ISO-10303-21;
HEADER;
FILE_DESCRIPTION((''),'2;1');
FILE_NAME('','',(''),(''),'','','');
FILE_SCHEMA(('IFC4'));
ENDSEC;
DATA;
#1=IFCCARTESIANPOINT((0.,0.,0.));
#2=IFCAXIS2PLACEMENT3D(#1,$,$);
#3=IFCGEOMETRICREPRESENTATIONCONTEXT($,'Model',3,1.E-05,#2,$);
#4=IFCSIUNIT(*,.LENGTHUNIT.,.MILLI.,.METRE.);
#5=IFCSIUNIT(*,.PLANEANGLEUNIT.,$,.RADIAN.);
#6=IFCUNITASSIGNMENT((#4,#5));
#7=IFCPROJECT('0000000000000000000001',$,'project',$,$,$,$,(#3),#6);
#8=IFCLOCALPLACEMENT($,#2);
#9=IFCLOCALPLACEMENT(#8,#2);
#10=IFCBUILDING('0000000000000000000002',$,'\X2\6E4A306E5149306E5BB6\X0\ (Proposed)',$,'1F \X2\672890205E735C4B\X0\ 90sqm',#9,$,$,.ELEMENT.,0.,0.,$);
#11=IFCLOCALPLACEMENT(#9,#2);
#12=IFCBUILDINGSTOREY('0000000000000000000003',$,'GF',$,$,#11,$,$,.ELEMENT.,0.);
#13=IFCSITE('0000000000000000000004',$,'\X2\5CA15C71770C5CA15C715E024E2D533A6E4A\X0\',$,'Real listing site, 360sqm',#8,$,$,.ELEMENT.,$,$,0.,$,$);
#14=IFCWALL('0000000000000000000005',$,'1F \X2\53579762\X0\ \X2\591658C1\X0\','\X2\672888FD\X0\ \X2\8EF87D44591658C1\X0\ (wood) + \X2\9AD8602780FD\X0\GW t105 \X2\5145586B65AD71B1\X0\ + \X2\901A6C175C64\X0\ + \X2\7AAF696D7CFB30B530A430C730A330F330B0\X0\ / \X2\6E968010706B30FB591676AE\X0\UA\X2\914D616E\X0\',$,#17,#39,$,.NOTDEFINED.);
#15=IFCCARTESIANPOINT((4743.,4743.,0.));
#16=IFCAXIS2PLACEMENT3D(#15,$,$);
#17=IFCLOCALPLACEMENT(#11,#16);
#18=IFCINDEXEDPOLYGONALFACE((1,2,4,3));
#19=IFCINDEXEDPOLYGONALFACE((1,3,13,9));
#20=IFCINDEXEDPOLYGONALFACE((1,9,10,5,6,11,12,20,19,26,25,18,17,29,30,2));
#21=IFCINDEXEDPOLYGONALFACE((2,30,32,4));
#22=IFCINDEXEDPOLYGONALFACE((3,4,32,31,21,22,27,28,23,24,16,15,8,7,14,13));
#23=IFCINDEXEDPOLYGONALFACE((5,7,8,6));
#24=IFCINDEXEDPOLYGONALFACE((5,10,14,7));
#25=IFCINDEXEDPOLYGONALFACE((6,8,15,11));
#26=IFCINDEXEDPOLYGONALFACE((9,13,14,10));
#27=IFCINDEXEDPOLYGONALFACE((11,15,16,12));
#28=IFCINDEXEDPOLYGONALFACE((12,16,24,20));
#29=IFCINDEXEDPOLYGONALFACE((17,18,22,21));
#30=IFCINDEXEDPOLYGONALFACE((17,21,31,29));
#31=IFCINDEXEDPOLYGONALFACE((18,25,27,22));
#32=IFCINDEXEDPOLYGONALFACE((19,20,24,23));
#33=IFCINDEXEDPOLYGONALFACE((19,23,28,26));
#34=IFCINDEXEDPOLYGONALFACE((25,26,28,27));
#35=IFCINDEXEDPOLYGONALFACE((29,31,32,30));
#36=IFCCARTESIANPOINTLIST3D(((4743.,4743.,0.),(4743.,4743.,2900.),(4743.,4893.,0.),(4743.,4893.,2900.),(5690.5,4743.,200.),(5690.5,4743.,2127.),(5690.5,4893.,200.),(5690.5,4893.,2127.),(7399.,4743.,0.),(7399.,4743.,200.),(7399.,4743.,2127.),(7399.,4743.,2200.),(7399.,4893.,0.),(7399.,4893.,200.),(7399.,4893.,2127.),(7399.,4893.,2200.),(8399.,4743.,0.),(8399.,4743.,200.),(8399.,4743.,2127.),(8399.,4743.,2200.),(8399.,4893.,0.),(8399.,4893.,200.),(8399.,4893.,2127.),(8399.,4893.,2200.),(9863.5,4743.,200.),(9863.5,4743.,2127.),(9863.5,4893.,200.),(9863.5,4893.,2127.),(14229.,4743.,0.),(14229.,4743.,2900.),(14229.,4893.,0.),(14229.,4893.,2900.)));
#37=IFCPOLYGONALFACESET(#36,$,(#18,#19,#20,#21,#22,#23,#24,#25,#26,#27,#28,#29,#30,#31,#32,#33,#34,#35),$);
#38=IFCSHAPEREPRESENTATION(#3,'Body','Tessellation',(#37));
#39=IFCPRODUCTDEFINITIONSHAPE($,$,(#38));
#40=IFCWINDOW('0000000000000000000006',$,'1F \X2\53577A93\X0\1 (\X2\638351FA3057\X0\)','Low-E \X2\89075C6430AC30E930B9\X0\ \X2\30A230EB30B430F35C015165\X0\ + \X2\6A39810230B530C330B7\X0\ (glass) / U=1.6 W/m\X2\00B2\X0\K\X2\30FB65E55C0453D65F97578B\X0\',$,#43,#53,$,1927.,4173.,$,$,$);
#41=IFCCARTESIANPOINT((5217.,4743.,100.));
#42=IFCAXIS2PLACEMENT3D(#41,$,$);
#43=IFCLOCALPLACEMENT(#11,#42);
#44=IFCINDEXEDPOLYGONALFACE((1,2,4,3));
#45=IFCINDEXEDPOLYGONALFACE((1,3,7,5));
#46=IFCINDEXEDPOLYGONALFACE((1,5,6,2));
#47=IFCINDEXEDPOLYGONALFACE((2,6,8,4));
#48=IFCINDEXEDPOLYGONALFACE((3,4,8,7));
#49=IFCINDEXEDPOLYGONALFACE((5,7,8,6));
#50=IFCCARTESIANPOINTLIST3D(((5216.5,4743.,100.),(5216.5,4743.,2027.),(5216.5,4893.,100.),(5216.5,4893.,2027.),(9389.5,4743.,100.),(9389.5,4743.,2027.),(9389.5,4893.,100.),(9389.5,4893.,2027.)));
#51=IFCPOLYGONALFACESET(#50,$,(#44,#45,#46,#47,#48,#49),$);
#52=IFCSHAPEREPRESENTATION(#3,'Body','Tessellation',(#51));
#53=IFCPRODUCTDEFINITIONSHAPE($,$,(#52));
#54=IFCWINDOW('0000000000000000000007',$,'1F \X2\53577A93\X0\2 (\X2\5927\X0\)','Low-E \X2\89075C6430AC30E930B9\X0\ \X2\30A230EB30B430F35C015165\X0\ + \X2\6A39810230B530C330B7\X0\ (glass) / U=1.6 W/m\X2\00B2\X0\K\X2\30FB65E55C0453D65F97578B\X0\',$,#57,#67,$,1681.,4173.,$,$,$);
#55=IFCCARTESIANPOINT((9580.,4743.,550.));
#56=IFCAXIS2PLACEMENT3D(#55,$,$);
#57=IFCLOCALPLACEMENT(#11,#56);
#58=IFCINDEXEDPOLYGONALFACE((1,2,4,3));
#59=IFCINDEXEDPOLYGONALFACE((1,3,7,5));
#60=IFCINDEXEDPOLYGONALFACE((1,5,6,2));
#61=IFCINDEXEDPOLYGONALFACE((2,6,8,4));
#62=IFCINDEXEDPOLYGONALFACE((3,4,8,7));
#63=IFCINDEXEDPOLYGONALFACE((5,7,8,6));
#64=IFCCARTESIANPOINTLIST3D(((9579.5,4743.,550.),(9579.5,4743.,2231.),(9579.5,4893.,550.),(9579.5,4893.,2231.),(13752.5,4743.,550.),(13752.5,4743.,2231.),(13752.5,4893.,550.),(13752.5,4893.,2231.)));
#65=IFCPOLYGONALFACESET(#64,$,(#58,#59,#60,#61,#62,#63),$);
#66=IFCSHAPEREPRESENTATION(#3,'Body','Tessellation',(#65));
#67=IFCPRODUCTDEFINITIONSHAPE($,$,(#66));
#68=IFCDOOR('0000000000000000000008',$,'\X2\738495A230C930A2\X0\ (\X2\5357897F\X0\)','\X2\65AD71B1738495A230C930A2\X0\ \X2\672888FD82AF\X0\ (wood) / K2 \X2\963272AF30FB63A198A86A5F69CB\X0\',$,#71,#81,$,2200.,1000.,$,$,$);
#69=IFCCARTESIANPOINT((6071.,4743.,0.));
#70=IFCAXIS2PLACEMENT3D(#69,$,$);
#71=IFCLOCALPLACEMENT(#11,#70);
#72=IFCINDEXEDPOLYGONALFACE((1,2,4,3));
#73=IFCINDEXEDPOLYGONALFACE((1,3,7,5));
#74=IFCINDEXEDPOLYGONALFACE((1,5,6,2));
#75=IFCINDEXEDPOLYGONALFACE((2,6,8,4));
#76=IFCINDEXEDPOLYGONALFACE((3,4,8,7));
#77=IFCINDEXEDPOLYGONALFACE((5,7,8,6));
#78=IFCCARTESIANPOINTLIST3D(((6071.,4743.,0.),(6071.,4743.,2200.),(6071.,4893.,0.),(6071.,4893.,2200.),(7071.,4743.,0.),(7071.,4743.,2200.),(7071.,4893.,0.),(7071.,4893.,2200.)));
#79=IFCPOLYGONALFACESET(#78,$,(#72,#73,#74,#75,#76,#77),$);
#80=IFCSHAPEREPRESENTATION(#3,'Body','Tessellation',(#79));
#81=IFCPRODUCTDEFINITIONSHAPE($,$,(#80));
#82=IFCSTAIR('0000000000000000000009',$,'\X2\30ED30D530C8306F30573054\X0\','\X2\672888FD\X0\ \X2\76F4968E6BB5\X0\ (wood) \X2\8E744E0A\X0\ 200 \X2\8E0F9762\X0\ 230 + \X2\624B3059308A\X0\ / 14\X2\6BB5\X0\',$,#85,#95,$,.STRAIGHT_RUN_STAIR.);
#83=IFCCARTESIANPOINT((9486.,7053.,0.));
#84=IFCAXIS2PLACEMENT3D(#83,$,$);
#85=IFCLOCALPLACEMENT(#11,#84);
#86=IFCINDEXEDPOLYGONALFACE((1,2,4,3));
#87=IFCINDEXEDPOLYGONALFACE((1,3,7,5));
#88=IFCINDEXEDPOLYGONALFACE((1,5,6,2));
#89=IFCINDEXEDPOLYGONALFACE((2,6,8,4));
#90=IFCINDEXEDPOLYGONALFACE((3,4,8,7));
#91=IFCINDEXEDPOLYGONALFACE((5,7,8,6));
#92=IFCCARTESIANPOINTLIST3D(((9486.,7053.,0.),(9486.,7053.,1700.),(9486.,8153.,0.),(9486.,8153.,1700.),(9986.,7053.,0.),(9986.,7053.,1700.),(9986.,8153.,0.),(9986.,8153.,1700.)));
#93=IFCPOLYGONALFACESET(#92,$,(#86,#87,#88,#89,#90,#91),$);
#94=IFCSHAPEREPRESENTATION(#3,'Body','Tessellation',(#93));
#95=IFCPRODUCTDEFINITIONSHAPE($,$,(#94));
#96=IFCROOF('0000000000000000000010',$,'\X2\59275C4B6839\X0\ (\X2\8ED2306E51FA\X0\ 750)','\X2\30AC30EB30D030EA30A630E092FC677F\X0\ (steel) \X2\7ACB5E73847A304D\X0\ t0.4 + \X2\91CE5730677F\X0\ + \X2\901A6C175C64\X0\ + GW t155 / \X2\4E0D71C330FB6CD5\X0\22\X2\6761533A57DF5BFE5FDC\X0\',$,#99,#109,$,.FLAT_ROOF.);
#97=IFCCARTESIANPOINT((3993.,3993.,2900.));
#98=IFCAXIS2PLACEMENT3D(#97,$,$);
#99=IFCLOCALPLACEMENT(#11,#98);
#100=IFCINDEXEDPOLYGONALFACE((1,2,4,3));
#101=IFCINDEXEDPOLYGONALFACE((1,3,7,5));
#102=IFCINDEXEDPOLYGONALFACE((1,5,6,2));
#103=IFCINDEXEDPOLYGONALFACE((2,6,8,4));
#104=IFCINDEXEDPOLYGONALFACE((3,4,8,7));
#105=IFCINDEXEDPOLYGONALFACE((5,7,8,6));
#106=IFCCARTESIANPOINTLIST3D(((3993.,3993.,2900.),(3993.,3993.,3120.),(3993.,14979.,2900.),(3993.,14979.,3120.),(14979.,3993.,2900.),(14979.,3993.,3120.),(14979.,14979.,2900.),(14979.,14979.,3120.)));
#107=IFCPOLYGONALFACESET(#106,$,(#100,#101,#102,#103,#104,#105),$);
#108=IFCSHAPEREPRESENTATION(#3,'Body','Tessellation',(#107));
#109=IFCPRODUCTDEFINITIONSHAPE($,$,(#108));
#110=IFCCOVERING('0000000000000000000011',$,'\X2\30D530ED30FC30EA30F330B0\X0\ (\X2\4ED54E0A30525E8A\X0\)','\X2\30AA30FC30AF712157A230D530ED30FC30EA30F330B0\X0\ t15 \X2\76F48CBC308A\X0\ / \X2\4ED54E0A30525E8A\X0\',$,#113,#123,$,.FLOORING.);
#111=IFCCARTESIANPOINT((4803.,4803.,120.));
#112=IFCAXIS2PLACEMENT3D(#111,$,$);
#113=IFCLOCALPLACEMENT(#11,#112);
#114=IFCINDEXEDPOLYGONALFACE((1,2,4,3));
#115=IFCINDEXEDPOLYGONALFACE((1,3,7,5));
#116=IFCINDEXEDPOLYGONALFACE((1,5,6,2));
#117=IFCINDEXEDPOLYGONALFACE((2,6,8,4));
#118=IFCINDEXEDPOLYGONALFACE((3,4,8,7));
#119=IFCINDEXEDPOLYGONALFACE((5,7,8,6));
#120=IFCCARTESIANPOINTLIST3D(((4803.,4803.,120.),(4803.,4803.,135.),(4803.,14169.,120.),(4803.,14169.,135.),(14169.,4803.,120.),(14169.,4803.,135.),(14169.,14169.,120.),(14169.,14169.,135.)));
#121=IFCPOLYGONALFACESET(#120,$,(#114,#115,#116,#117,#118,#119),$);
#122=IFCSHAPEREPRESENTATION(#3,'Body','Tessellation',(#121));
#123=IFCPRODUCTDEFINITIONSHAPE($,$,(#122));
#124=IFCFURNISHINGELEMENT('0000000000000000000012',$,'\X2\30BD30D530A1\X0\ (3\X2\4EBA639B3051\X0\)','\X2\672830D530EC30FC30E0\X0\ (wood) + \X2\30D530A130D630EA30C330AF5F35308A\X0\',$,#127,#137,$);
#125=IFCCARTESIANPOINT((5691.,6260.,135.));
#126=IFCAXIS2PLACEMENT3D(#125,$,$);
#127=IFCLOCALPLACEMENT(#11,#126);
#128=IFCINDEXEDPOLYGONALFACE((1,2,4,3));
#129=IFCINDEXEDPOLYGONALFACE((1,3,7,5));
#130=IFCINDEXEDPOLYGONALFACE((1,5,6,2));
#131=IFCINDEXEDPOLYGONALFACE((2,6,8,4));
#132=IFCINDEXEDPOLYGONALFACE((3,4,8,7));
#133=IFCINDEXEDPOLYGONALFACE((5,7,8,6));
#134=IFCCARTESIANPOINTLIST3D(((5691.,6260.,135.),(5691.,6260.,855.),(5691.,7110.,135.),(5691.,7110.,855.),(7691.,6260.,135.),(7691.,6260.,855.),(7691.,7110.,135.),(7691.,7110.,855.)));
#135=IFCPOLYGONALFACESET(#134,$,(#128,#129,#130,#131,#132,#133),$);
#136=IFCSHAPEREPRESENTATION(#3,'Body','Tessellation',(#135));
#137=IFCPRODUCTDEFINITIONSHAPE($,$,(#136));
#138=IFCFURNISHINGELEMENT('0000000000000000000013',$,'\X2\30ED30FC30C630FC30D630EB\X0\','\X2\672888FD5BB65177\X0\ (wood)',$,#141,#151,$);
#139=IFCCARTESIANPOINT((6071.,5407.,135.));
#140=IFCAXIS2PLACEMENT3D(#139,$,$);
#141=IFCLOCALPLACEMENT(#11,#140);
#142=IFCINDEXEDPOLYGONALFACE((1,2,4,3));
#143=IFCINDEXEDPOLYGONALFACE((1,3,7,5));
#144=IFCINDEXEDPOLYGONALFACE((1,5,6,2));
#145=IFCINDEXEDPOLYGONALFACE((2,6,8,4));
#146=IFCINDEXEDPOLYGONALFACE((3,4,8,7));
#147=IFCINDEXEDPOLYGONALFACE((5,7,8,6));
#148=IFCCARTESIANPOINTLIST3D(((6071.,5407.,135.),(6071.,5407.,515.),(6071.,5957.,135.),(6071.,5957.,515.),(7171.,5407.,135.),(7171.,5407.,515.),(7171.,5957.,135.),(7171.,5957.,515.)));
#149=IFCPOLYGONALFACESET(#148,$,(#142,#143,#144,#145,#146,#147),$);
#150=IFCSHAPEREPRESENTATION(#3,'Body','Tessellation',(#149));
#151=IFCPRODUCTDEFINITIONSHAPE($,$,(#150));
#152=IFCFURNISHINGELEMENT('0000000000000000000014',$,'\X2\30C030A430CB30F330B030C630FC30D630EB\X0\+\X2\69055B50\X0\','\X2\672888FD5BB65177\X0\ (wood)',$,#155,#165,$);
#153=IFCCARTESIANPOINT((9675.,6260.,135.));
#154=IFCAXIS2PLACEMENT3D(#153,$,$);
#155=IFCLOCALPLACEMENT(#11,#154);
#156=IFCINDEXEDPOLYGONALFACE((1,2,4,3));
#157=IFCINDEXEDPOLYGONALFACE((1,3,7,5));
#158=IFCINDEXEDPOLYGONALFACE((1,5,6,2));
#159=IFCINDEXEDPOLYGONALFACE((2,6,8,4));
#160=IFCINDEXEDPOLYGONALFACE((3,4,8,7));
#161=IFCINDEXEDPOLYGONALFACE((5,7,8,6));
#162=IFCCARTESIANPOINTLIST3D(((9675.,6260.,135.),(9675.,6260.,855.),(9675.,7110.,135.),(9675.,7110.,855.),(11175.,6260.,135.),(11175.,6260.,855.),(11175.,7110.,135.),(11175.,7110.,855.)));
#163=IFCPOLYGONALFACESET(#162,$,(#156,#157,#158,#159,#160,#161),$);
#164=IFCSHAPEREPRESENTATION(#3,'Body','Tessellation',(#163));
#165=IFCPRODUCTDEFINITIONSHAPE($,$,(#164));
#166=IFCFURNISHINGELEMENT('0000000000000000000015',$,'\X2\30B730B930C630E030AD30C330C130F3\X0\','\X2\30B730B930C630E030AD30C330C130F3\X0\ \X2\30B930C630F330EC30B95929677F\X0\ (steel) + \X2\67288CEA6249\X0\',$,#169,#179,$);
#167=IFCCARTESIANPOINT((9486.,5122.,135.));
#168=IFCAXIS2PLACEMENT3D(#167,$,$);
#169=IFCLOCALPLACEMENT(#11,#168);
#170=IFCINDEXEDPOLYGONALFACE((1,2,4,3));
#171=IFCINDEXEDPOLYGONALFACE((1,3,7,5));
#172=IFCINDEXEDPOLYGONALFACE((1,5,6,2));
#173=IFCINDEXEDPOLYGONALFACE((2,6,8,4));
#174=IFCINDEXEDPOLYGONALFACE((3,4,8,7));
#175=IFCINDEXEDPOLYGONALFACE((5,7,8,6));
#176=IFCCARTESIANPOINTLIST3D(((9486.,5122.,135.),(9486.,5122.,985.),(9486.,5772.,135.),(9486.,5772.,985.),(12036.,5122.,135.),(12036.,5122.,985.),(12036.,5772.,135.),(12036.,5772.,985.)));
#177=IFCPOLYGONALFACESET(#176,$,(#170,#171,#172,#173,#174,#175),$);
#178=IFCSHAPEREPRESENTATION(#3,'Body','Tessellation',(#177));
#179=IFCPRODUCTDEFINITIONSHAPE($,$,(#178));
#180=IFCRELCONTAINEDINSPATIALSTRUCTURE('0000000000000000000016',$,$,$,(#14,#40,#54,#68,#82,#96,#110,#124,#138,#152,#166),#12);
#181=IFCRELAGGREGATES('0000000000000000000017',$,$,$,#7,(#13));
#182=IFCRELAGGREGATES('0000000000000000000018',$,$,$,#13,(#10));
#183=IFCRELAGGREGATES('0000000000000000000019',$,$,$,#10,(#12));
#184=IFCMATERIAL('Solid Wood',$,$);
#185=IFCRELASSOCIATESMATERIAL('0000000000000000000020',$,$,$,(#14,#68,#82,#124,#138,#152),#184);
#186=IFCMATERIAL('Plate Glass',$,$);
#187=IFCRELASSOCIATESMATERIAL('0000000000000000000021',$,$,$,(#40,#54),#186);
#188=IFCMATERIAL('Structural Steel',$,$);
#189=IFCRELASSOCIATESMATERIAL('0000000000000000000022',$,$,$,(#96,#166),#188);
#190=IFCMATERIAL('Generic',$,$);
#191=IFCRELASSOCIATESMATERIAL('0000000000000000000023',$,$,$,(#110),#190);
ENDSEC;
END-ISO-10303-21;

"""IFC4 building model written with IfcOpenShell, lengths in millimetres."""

from ifc_helpers import new_model, si_unit, frame, frame_2d, origin, place, context, project, spatial, rectangle, extrude, material, element, fill, save


model = new_model("IFC4")

# Units and contexts
model_context = context("Model", 3, precision=1e-05, world=origin())
ifc_project = project(units=[si_unit("LENGTHUNIT", "METRE", prefix="MILLI"), si_unit("PLANEANGLEUNIT", "RADIAN")], contexts=[model_context])

# Site, building, storey
site_placement = place(None, origin())
site = spatial("IfcSite", under=ifc_project, at=site_placement, Name="岡山県岡山市中区湊", ObjectType="Real listing site, 360sqm", CompositionType="ELEMENT", RefElevation=0.0)
building_placement = place(site_placement, origin())
building = spatial("IfcBuilding", under=site, at=building_placement, Name="湊の光の家 (Proposed)", ObjectType="1F 木造平屋 90sqm", CompositionType="ELEMENT", ElevationOfRefHeight=0.0, ElevationOfTerrain=0.0)
storey_placement = place(building_placement, origin())
storey = spatial("IfcBuildingStorey", under=building, at=storey_placement, Name="GF", CompositionType="ELEMENT", Elevation=0.0)

# Shared definitions
ifc_material_1 = material(Name="Solid Wood")

# Wall, openings, windows, door
wall_1_placement = place(storey_placement, frame((4743.0, 4743.0, 0.0)))
wall_1 = element("IfcWall", 1, at=wall_1_placement, inside=storey, material=ifc_material_1, Name="1F 南面 外壁", Description="木製 軸組外壁 (wood) + 高性能GW t105 充填断熱 + 通気層 + 窯業系サイディング / 準耐火・外皮UA配慮", PredefinedType="NOTDEFINED", context=model_context, shape_type="SweptSolid", body=[
    extrude(rectangle(XDim=9486.0, YDim=150.0, at=frame_2d((4743.0, 75.0))), frame((4743.0, 4743.0, 0.0)), (0.0, 0.0, 1.0), 2900.0),
])
opening_1_placement = place(storey_placement, frame((5217.0, 4743.0, 100.0)))
opening_1 = element("IfcOpeningElement", 2, at=opening_1_placement, cuts=wall_1, PredefinedType="NOTDEFINED", context=model_context, shape_type="SweptSolid", body=[
    extrude(rectangle(XDim=4173.0, YDim=150.0, at=frame_2d((2086.0, 75.0))), frame((5217.0, 4743.0, 100.0)), (0.0, 0.0, 1.0), 1927.0),
])
opening_2_placement = place(storey_placement, frame((9580.0, 4743.0, 550.0)))
opening_2 = element("IfcOpeningElement", 3, at=opening_2_placement, cuts=wall_1, PredefinedType="NOTDEFINED", context=model_context, shape_type="SweptSolid", body=[
    extrude(rectangle(XDim=4173.0, YDim=150.0, at=frame_2d((2086.0, 75.0))), frame((9580.0, 4743.0, 550.0)), (0.0, 0.0, 1.0), 1681.0),
])
opening_3_placement = place(storey_placement, frame((6071.0, 4743.0, 0.0)))
opening_3 = element("IfcOpeningElement", 4, at=opening_3_placement, cuts=wall_1, PredefinedType="NOTDEFINED", context=model_context, shape_type="SweptSolid", body=[
    extrude(rectangle(XDim=1000.0, YDim=150.0, at=frame_2d((500.0, 75.0))), frame((6071.0, 4743.0, 0.0)), (0.0, 0.0, 1.0), 2200.0),
])
ifc_material_2 = material(Name="Plate Glass")
window_1_placement = place(storey_placement, frame((5217.0, 4743.0, 100.0)))
window_1 = element("IfcWindow", 5, at=window_1_placement, inside=storey, material=ifc_material_2, Name="1F 南窓1 (掃出し)", Description="Low-E 複層ガラス アルゴン封入 + 樹脂サッシ (glass) / U=1.6 W/m²K・日射取得型", OverallHeight=1927.0, OverallWidth=4173.0, context=model_context, shape_type="SweptSolid", body=[
    extrude(rectangle(XDim=4173.0, YDim=150.0, at=frame_2d((2086.0, 75.0))), frame((5217.0, 4743.0, 100.0)), (0.0, 0.0, 1.0), 1927.0),
])
fill(opening_1, window_1)
window_2_placement = place(storey_placement, frame((9580.0, 4743.0, 550.0)))
window_2 = element("IfcWindow", 6, at=window_2_placement, inside=storey, material=ifc_material_2, Name="1F 南窓2 (大)", Description="Low-E 複層ガラス アルゴン封入 + 樹脂サッシ (glass) / U=1.6 W/m²K・日射取得型", OverallHeight=1681.0, OverallWidth=4173.0, context=model_context, shape_type="SweptSolid", body=[
    extrude(rectangle(XDim=4173.0, YDim=150.0, at=frame_2d((2086.0, 75.0))), frame((9580.0, 4743.0, 550.0)), (0.0, 0.0, 1.0), 1681.0),
])
fill(opening_2, window_2)
door_placement = place(storey_placement, frame((6071.0, 4743.0, 0.0)))
door = element("IfcDoor", 7, at=door_placement, inside=storey, material=ifc_material_1, Name="玄関ドア (南西)", Description="断熱玄関ドア 木製芯 (wood) / K2 防犯・採風機構", OverallHeight=2200.0, OverallWidth=1000.0, context=model_context, shape_type="SweptSolid", body=[
    extrude(rectangle(XDim=1000.0, YDim=150.0, at=frame_2d((500.0, 75.0))), frame((6071.0, 4743.0, 0.0)), (0.0, 0.0, 1.0), 2200.0),
])
fill(opening_3, door)

# Stair
stair_placement = place(storey_placement, frame((9486.0, 7053.0, 0.0)))
element("IfcStair", 8, at=stair_placement, inside=storey, material=ifc_material_1, Name="ロフトはしご", Description="木製 直階段 (wood) 蹴上 200 踏面 230 + 手すり / 14段", PredefinedType="STRAIGHT_RUN_STAIR", context=model_context, shape_type="SweptSolid", body=[
    extrude(rectangle(XDim=500.0, YDim=1100.0, at=frame_2d((250.0, 550.0))), frame((9486.0, 7053.0, 0.0)), (0.0, 0.0, 1.0), 1700.0),
])

# Roof
ifc_material_3 = material(Name="Structural Steel")
roof_placement = place(storey_placement, frame((3993.0, 3993.0, 2900.0)))
element("IfcRoof", 9, at=roof_placement, inside=storey, material=ifc_material_3, Name="大屋根 (軒の出 750)", Description="ガルバリウム鋼板 (steel) 立平葺き t0.4 + 野地板 + 通気層 + GW t155 / 不燃・法22条区域対応", PredefinedType="FLAT_ROOF", context=model_context, shape_type="SweptSolid", body=[
    extrude(rectangle(XDim=10986.0, YDim=10986.0, at=frame_2d((5493.0, 5493.0))), frame((3993.0, 3993.0, 2900.0)), (0.0, 0.0, 1.0), 220.0),
])

# Covering
ifc_material_4 = material(Name="Generic")
covering_placement = place(storey_placement, frame((4803.0, 4803.0, 120.0)))
element("IfcCovering", 10, at=covering_placement, inside=storey, material=ifc_material_4, Name="フローリング (仕上げ床)", Description="オーク無垢フローリング t15 直貼り / 仕上げ床", PredefinedType="FLOORING", context=model_context, shape_type="SweptSolid", body=[
    extrude(rectangle(XDim=9366.0, YDim=9366.0, at=frame_2d((4683.0, 4683.0))), frame((4803.0, 4803.0, 120.0)), (0.0, 0.0, 1.0), 15.0),
])

# Furnishing elements
furnishing_1_placement = place(storey_placement, frame((5691.0, 6260.0, 135.0)))
element("IfcFurnishingElement", 11, at=furnishing_1_placement, inside=storey, material=ifc_material_1, Name="ソファ (3人掛け)", Description="木フレーム (wood) + ファブリック張り", context=model_context, shape_type="SweptSolid", body=[
    extrude(rectangle(XDim=2000.0, YDim=850.0, at=frame_2d((1000.0, 425.0))), frame((5691.0, 6260.0, 135.0)), (0.0, 0.0, 1.0), 720.0),
])
furnishing_2_placement = place(storey_placement, frame((6071.0, 5407.0, 135.0)))
element("IfcFurnishingElement", 12, at=furnishing_2_placement, inside=storey, material=ifc_material_1, Name="ローテーブル", Description="木製家具 (wood)", context=model_context, shape_type="SweptSolid", body=[
    extrude(rectangle(XDim=1100.0, YDim=550.0, at=frame_2d((550.0, 275.0))), frame((6071.0, 5407.0, 135.0)), (0.0, 0.0, 1.0), 380.0),
])
furnishing_3_placement = place(storey_placement, frame((9675.0, 6260.0, 135.0)))
element("IfcFurnishingElement", 13, at=furnishing_3_placement, inside=storey, material=ifc_material_1, Name="ダイニングテーブル+椅子", Description="木製家具 (wood)", context=model_context, shape_type="SweptSolid", body=[
    extrude(rectangle(XDim=1500.0, YDim=850.0, at=frame_2d((750.0, 425.0))), frame((9675.0, 6260.0, 135.0)), (0.0, 0.0, 1.0), 720.0),
])
furnishing_4_placement = place(storey_placement, frame((9486.0, 5122.0, 135.0)))
element("IfcFurnishingElement", 14, at=furnishing_4_placement, inside=storey, material=ifc_material_3, Name="システムキッチン", Description="システムキッチン ステンレス天板 (steel) + 木質扉", context=model_context, shape_type="SweptSolid", body=[
    extrude(rectangle(XDim=2550.0, YDim=650.0, at=frame_2d((1275.0, 325.0))), frame((9486.0, 5122.0, 135.0)), (0.0, 0.0, 1.0), 850.0),
])

save(model, "model.ifc")
